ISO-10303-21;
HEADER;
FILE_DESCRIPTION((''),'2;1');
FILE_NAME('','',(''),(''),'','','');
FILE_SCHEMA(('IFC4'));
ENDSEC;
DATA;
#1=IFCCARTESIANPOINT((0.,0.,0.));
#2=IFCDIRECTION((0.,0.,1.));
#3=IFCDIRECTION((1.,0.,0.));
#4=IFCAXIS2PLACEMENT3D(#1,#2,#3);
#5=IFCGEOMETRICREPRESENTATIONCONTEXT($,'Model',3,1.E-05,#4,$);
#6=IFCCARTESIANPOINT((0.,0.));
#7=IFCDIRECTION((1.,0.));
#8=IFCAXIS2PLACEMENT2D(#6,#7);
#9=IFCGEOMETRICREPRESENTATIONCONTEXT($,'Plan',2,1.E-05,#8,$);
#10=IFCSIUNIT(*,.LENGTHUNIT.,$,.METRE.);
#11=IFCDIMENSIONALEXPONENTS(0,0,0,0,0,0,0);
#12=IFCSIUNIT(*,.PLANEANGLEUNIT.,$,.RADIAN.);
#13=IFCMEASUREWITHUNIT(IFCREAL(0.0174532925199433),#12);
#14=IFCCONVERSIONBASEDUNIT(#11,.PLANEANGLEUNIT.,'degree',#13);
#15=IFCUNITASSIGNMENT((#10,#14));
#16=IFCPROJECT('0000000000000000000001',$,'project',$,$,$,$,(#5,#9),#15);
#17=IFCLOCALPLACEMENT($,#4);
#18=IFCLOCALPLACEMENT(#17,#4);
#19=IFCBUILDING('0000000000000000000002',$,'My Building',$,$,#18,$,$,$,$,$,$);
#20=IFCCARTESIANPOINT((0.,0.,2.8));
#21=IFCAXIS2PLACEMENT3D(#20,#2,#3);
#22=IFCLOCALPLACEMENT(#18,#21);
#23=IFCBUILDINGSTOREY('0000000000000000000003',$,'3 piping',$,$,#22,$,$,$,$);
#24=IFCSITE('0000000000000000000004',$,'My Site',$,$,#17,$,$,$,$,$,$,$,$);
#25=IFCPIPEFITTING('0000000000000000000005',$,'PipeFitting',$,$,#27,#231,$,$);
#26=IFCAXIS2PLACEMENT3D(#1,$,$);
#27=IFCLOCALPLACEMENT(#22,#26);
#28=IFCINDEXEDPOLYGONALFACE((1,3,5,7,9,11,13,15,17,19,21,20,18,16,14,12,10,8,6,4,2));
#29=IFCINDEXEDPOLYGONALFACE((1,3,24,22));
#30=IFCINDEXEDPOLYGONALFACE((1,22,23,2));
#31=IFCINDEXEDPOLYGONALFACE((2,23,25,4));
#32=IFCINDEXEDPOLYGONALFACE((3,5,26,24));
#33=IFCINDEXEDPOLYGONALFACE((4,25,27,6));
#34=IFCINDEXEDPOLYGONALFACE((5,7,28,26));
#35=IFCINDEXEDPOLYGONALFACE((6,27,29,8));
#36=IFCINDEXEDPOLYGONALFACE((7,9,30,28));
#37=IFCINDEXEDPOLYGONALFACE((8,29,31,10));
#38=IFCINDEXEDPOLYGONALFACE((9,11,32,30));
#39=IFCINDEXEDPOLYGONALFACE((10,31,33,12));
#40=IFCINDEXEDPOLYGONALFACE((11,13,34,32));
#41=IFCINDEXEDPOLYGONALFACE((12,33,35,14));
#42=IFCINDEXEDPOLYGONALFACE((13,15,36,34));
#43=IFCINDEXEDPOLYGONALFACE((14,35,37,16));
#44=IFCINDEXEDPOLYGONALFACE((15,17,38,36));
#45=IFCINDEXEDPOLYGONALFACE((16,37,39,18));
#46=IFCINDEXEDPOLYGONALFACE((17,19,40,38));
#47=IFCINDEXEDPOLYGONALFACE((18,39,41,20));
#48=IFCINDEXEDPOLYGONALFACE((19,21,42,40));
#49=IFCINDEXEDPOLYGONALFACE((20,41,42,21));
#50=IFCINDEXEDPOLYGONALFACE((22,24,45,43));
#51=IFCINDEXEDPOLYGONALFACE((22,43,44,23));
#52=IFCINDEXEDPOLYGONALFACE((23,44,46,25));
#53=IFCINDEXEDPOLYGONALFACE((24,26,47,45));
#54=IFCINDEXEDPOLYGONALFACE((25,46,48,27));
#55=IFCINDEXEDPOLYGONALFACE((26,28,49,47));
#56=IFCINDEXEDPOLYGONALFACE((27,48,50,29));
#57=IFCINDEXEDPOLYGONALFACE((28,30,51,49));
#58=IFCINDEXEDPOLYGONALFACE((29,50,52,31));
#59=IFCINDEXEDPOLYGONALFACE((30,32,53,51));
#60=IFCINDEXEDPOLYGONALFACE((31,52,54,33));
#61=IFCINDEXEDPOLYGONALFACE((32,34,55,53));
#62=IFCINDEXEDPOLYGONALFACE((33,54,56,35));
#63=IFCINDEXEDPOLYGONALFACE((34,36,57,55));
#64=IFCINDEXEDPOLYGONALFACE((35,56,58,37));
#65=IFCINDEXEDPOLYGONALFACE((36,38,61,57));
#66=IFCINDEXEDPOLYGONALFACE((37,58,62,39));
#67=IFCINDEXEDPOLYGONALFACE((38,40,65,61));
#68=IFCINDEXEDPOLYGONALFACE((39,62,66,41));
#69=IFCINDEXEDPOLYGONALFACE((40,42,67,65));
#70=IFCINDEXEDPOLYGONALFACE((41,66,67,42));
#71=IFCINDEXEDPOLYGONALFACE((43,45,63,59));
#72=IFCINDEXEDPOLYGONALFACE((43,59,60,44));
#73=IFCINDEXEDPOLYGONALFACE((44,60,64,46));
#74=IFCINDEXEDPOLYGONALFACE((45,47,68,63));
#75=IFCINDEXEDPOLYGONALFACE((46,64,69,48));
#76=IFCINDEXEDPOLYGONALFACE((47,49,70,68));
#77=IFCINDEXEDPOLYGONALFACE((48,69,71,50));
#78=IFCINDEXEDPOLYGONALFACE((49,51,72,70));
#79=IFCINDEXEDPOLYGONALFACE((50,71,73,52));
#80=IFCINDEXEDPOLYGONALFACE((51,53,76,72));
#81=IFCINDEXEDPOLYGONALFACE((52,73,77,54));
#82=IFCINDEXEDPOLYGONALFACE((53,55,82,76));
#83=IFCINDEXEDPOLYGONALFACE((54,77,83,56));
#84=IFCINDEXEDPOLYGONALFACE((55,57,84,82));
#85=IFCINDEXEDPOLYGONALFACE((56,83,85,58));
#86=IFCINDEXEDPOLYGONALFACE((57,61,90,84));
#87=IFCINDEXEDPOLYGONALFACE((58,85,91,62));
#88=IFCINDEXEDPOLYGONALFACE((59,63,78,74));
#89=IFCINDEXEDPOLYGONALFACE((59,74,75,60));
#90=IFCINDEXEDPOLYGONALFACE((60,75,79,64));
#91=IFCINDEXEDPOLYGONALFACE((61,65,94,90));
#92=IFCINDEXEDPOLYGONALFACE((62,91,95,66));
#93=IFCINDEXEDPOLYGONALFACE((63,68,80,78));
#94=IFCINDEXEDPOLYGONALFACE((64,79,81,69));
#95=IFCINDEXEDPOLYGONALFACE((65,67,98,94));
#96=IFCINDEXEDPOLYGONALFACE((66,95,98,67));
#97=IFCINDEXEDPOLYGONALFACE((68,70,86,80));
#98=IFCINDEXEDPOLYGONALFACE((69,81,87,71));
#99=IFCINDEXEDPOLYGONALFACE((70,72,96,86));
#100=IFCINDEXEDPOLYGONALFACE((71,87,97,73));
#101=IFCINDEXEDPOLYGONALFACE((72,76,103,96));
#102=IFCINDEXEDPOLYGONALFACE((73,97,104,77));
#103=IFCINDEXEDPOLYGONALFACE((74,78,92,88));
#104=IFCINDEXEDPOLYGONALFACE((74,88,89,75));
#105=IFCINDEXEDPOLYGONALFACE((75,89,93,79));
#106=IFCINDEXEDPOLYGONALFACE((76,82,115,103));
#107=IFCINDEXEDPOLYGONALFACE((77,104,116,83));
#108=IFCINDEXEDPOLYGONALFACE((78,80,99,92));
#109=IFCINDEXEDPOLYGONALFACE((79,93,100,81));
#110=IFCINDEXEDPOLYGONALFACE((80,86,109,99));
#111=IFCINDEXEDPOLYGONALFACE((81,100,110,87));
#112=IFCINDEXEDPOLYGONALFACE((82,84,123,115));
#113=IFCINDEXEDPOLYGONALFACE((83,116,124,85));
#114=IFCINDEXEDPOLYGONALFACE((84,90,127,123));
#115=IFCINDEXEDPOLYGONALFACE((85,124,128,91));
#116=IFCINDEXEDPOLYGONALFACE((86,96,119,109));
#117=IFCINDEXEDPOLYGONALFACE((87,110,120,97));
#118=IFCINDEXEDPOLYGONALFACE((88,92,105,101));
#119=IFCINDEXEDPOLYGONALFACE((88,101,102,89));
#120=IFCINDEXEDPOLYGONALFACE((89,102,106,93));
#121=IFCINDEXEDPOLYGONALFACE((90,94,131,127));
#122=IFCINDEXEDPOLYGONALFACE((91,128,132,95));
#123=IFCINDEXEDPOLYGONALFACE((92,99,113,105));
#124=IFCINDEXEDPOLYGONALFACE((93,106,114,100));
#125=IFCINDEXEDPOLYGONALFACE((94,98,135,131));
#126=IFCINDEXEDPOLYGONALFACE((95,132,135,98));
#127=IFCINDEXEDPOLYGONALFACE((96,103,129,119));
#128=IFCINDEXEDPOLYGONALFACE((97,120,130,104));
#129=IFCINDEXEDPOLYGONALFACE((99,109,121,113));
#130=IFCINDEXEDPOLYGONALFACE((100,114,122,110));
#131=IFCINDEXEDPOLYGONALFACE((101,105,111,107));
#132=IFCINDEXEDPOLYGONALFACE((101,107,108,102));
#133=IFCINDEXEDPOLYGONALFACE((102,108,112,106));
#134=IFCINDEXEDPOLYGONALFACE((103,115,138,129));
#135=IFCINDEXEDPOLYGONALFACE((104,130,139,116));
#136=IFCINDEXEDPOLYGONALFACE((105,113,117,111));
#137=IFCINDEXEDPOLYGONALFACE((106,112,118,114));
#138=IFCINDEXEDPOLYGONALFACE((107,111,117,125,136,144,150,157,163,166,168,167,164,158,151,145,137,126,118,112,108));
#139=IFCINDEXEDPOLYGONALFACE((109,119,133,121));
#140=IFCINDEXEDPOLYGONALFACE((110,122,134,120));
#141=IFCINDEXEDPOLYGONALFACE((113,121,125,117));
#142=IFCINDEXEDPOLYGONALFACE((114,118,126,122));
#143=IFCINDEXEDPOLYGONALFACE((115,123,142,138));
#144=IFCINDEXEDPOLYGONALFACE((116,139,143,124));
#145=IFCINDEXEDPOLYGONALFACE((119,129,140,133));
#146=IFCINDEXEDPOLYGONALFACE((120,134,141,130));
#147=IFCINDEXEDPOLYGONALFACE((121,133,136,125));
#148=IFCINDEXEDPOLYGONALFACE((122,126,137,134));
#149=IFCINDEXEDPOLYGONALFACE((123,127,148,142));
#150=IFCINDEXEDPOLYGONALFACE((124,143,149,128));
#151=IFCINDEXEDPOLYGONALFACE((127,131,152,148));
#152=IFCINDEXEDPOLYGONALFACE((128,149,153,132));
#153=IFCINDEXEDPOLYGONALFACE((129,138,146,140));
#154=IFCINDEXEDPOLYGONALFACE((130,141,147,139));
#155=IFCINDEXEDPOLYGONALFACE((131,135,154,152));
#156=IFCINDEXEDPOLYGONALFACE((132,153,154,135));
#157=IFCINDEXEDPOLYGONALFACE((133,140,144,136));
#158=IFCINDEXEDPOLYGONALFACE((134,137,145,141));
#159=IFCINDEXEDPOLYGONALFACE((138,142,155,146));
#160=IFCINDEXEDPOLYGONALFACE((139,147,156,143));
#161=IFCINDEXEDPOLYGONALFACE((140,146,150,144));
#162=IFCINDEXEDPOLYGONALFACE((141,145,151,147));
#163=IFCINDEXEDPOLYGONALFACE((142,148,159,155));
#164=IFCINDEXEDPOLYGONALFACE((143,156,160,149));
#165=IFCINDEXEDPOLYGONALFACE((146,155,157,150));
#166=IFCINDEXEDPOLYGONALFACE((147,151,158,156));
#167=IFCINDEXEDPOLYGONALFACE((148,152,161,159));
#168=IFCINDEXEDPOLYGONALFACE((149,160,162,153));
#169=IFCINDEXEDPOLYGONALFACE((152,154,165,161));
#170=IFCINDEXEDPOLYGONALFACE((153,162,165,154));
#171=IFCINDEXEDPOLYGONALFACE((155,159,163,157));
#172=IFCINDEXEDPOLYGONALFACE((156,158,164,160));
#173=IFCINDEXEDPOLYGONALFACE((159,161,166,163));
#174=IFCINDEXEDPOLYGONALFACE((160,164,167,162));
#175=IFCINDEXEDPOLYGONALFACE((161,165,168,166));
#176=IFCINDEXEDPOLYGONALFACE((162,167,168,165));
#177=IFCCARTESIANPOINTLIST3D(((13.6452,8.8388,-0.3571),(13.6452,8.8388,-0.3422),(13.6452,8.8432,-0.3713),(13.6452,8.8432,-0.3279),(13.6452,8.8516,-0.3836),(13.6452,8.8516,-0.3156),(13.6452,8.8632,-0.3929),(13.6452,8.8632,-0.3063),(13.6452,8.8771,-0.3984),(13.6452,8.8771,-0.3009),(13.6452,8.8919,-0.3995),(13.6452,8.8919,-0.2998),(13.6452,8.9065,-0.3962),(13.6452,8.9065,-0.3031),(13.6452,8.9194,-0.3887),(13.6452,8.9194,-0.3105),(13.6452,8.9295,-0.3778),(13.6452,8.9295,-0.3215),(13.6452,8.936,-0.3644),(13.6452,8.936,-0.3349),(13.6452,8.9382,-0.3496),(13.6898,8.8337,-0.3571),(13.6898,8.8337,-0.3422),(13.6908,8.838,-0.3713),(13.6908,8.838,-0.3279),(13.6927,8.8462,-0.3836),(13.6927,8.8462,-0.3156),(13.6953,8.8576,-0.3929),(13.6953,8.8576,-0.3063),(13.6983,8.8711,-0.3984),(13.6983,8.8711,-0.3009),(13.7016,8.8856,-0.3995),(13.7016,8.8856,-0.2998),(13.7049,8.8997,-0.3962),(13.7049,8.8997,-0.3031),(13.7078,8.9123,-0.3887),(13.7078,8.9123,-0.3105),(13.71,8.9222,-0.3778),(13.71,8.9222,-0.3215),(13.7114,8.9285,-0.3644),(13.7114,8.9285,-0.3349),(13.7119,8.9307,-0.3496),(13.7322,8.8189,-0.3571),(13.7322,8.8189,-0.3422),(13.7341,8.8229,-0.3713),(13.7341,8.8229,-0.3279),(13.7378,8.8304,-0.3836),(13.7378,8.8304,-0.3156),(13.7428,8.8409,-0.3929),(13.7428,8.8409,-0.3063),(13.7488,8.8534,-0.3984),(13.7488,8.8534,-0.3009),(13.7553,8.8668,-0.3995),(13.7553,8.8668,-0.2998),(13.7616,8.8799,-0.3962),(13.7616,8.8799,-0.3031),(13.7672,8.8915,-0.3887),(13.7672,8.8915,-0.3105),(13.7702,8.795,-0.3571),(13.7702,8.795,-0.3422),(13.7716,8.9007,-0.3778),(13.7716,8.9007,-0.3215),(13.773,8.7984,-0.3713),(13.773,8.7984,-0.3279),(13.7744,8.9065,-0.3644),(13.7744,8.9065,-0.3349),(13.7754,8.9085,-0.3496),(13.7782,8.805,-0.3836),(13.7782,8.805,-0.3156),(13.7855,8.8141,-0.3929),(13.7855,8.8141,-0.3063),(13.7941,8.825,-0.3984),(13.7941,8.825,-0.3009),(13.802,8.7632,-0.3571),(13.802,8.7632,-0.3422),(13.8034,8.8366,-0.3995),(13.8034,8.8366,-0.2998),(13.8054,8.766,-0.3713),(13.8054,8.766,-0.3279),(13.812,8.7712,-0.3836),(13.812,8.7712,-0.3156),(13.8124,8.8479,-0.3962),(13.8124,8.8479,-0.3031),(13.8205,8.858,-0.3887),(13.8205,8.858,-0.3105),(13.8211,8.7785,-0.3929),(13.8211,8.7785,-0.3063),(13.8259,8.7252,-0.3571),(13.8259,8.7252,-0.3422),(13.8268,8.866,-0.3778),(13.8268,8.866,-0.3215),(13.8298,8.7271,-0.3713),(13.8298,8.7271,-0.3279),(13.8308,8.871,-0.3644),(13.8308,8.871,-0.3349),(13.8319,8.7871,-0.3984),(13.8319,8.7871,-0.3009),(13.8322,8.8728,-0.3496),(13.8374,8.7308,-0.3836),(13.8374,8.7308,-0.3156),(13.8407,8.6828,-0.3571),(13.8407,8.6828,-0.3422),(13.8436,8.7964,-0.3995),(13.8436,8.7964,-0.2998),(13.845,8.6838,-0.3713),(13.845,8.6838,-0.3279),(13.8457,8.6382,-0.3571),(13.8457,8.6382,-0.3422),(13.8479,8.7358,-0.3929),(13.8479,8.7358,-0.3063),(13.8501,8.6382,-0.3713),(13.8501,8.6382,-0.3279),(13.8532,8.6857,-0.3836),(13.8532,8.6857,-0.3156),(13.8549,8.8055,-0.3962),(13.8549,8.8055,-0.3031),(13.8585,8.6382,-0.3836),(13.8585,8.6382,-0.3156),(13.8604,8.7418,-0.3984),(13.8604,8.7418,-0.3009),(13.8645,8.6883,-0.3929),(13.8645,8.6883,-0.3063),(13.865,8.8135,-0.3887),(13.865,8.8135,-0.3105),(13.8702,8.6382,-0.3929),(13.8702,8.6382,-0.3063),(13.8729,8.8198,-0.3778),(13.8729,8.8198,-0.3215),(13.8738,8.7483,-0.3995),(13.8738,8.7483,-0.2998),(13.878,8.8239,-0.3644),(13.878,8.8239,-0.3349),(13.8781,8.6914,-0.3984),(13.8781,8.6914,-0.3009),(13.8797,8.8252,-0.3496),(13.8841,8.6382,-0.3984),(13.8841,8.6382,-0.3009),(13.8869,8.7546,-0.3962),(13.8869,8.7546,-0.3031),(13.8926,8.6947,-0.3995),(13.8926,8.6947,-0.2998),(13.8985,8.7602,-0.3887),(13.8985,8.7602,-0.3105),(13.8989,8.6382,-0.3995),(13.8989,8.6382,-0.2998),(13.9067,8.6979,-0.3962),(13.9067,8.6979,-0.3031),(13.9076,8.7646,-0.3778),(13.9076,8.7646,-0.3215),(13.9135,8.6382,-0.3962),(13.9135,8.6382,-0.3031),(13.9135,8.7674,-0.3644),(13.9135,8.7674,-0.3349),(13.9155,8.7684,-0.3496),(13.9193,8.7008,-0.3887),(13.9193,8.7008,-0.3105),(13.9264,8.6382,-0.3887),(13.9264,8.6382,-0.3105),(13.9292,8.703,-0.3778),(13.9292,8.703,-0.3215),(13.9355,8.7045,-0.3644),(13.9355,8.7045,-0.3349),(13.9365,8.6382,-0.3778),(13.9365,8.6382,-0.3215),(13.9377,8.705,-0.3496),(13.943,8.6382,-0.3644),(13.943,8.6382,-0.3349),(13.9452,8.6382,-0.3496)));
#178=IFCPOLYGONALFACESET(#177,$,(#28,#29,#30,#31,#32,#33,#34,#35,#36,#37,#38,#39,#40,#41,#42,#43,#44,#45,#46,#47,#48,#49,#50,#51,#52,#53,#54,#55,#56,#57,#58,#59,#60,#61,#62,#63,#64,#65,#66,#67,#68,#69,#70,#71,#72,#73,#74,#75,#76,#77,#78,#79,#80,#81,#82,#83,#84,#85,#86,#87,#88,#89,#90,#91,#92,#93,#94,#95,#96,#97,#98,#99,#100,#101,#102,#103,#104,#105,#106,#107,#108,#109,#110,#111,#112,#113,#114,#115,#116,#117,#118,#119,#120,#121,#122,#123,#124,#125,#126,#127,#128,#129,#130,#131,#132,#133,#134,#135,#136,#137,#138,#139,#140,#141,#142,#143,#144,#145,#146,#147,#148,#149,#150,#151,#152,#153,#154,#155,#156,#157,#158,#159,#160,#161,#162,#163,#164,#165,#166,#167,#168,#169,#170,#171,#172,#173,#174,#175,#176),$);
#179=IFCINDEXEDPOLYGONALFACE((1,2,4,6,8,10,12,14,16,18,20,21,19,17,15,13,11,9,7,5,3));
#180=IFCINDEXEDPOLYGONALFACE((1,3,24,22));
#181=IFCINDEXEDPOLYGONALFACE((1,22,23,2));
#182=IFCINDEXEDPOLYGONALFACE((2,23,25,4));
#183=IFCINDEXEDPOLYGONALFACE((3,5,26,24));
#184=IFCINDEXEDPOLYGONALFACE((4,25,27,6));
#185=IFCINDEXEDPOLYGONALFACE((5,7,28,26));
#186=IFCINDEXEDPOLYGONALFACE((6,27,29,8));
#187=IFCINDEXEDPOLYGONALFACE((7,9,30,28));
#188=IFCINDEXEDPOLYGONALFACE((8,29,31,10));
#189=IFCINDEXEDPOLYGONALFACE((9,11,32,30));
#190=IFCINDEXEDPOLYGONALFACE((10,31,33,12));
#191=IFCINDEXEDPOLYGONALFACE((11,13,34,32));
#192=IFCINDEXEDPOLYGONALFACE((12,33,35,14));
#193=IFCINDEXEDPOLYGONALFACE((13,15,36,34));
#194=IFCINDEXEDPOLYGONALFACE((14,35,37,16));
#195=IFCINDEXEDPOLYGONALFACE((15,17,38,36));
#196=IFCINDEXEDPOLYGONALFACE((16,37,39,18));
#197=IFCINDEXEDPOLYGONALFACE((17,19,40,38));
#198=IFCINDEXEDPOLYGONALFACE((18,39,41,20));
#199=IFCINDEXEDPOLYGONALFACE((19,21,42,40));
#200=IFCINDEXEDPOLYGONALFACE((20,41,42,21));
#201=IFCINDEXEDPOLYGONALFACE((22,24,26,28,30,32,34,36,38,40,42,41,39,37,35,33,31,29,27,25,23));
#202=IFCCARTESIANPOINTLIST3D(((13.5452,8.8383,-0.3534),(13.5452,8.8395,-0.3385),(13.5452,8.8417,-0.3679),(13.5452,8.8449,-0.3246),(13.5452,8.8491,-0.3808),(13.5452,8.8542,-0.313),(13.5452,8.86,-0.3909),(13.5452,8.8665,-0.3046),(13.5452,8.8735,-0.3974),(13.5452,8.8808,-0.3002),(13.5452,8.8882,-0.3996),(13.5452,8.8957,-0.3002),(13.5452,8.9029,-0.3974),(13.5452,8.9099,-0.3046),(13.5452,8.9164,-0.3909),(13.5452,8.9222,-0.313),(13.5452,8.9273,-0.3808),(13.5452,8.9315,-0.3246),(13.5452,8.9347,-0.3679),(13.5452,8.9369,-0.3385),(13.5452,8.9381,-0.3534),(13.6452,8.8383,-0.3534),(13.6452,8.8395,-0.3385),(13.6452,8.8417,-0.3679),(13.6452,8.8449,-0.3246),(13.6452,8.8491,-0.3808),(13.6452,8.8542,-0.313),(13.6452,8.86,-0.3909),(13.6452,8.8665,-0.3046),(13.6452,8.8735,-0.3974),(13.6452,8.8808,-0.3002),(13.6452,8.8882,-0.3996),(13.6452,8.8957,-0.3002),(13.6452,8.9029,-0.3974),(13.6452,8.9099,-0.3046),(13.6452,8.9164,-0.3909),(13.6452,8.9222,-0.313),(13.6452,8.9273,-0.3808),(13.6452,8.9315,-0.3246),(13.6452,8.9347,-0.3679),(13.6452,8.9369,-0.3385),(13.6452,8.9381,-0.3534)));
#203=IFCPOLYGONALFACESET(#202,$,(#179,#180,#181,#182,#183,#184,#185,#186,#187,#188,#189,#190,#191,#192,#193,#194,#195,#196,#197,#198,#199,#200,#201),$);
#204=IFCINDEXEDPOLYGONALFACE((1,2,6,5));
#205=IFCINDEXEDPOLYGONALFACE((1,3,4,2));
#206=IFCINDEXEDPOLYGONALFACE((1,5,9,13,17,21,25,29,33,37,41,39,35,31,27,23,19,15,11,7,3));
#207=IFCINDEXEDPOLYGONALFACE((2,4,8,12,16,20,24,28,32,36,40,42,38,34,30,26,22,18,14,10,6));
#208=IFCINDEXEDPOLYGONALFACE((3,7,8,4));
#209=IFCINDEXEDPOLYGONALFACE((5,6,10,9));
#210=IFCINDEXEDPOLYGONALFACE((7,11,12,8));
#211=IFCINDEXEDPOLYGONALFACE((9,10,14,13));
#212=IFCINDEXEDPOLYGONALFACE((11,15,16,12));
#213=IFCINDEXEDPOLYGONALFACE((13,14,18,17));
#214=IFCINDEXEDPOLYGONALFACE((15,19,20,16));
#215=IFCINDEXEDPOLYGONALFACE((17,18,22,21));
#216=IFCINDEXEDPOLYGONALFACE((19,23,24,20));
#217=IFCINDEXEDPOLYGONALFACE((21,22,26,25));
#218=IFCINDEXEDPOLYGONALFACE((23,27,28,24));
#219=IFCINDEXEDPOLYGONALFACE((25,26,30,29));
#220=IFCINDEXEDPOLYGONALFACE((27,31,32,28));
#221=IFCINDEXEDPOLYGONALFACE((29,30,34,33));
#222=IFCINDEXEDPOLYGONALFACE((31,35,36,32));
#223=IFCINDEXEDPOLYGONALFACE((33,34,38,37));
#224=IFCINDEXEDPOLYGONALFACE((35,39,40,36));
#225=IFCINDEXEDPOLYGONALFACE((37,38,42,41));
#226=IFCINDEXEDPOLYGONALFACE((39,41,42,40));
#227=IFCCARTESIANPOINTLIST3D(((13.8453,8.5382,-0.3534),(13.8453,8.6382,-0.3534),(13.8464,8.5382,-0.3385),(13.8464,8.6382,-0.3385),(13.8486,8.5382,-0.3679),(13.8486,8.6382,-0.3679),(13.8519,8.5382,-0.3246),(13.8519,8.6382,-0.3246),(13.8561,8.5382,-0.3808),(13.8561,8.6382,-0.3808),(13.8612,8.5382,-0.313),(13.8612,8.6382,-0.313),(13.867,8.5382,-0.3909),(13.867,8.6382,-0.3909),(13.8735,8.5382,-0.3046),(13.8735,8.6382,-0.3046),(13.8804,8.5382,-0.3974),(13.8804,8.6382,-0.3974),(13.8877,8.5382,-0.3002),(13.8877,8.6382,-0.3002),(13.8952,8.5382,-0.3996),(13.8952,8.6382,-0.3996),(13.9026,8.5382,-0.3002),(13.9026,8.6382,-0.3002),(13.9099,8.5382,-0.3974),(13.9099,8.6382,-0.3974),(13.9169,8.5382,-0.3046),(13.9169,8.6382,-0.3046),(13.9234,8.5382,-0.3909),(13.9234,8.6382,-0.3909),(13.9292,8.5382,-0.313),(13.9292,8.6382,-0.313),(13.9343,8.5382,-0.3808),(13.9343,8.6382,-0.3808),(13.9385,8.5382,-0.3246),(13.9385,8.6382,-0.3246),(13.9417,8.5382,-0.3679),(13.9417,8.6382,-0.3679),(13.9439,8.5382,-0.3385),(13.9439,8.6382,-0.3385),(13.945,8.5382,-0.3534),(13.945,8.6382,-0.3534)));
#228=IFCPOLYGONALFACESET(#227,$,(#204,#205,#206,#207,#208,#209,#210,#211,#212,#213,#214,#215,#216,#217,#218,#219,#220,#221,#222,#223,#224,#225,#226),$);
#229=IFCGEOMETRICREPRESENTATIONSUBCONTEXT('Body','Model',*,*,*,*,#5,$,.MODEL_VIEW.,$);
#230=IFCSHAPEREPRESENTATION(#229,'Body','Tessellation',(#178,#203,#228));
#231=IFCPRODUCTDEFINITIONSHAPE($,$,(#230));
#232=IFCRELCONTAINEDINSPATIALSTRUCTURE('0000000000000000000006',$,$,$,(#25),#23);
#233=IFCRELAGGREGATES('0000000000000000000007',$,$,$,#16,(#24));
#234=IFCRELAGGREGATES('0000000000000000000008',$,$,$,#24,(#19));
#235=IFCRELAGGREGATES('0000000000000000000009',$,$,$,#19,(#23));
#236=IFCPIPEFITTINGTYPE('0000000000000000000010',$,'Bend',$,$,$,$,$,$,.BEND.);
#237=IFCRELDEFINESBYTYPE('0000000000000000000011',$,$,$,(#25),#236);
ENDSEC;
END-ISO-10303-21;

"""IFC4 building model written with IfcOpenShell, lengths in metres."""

from ifc_helpers import new_model, entity, si_unit, converted_unit, frame, origin_with_axes, origin_2d_with_axis, place, context, subcontext, project, spatial, circle, extrude, source, transform, mapped, type_object, type_shapes, element, save


model = new_model("IFC4")

# Units and contexts
model_context = context("Model", 3, precision=1e-05, world=origin_with_axes())
plan_context = context("Plan", 2, precision=1e-05, world=origin_2d_with_axis())
body_context = subcontext(model_context, "Body", "Model", "MODEL_VIEW")
ifc_project = project(units=[si_unit("LENGTHUNIT", "METRE"), converted_unit("PLANEANGLEUNIT", "degree", entity("IfcReal", 0.0174532925199433), si_unit("PLANEANGLEUNIT", "RADIAN"), dimensions=[0, 0, 0, 0, 0, 0, 0])], contexts=[model_context, plan_context])

# Site, building, storey
site_placement = place(None, origin_with_axes())
site = spatial("IfcSite", under=ifc_project, at=site_placement, Name="My Site")
building_placement = place(site_placement, origin_with_axes())
building = spatial("IfcBuilding", under=site, at=building_placement, Name="My Building")
storey_placement = place(building_placement, frame((0.0, 0.0, 2.8), z_axis=(0.0, 0.0, 1.0), x_axis=(1.0, 0.0, 0.0)))
storey = spatial("IfcBuildingStorey", under=building, at=storey_placement, Name="3 piping")

# Pipe fitting
pipe_fitting_type_1 = type_object("IfcPipeFittingType", Name="Bend", PredefinedType="BEND")
shared_shape = source(origin_with_axes(), body_context, "Body", "SolidModel", [
    entity("IfcSweptDiskSolid", entity("IfcIndexedPolyCurve", entity("IfcCartesianPointList3D", [[0.0, 0.0, 0.1], [0.0, -0.0732, 0.2768], [0.0, -0.25, 0.35]]), [entity("IfcArcIndex", [1, 2, 3])]), 0.05),
    extrude(circle(Radius=0.05), origin_with_axes(), (0.0, 0.0, 1.0), 0.1),
    extrude(circle(Radius=0.05), frame((0.0, -0.25, 0.35), z_axis=(0.0, -1.0, 0.0), x_axis=(1.0, 0.0, 0.0)), (0.0, 0.0, 1.0), 0.1),
])
type_shapes(pipe_fitting_type_1, [shared_shape])
for number, where, z_axis, x_axis, name in (
    (1, (13.5452, 8.8882, -0.3496), (1.0, 0.0, 0.0), (0.0, 0.0, -1.0), "PipeFitting"),
):
    element("IfcPipeFitting", number, at=place(storey_placement, frame(where, z_axis=z_axis, x_axis=x_axis)), inside=storey, type_object=pipe_fitting_type_1, Name=name, context=body_context, shape_type="MappedRepresentation", body=[
        mapped(shared_shape, transform((0.0, 0.0, 0.0), x_axis=(1.0, 0.0, 0.0), y_axis=(0.0, 1.0, 0.0), z_axis=(0.0, 0.0, 1.0), scale=1.0)),
    ])

save(model, "model.ifc")
